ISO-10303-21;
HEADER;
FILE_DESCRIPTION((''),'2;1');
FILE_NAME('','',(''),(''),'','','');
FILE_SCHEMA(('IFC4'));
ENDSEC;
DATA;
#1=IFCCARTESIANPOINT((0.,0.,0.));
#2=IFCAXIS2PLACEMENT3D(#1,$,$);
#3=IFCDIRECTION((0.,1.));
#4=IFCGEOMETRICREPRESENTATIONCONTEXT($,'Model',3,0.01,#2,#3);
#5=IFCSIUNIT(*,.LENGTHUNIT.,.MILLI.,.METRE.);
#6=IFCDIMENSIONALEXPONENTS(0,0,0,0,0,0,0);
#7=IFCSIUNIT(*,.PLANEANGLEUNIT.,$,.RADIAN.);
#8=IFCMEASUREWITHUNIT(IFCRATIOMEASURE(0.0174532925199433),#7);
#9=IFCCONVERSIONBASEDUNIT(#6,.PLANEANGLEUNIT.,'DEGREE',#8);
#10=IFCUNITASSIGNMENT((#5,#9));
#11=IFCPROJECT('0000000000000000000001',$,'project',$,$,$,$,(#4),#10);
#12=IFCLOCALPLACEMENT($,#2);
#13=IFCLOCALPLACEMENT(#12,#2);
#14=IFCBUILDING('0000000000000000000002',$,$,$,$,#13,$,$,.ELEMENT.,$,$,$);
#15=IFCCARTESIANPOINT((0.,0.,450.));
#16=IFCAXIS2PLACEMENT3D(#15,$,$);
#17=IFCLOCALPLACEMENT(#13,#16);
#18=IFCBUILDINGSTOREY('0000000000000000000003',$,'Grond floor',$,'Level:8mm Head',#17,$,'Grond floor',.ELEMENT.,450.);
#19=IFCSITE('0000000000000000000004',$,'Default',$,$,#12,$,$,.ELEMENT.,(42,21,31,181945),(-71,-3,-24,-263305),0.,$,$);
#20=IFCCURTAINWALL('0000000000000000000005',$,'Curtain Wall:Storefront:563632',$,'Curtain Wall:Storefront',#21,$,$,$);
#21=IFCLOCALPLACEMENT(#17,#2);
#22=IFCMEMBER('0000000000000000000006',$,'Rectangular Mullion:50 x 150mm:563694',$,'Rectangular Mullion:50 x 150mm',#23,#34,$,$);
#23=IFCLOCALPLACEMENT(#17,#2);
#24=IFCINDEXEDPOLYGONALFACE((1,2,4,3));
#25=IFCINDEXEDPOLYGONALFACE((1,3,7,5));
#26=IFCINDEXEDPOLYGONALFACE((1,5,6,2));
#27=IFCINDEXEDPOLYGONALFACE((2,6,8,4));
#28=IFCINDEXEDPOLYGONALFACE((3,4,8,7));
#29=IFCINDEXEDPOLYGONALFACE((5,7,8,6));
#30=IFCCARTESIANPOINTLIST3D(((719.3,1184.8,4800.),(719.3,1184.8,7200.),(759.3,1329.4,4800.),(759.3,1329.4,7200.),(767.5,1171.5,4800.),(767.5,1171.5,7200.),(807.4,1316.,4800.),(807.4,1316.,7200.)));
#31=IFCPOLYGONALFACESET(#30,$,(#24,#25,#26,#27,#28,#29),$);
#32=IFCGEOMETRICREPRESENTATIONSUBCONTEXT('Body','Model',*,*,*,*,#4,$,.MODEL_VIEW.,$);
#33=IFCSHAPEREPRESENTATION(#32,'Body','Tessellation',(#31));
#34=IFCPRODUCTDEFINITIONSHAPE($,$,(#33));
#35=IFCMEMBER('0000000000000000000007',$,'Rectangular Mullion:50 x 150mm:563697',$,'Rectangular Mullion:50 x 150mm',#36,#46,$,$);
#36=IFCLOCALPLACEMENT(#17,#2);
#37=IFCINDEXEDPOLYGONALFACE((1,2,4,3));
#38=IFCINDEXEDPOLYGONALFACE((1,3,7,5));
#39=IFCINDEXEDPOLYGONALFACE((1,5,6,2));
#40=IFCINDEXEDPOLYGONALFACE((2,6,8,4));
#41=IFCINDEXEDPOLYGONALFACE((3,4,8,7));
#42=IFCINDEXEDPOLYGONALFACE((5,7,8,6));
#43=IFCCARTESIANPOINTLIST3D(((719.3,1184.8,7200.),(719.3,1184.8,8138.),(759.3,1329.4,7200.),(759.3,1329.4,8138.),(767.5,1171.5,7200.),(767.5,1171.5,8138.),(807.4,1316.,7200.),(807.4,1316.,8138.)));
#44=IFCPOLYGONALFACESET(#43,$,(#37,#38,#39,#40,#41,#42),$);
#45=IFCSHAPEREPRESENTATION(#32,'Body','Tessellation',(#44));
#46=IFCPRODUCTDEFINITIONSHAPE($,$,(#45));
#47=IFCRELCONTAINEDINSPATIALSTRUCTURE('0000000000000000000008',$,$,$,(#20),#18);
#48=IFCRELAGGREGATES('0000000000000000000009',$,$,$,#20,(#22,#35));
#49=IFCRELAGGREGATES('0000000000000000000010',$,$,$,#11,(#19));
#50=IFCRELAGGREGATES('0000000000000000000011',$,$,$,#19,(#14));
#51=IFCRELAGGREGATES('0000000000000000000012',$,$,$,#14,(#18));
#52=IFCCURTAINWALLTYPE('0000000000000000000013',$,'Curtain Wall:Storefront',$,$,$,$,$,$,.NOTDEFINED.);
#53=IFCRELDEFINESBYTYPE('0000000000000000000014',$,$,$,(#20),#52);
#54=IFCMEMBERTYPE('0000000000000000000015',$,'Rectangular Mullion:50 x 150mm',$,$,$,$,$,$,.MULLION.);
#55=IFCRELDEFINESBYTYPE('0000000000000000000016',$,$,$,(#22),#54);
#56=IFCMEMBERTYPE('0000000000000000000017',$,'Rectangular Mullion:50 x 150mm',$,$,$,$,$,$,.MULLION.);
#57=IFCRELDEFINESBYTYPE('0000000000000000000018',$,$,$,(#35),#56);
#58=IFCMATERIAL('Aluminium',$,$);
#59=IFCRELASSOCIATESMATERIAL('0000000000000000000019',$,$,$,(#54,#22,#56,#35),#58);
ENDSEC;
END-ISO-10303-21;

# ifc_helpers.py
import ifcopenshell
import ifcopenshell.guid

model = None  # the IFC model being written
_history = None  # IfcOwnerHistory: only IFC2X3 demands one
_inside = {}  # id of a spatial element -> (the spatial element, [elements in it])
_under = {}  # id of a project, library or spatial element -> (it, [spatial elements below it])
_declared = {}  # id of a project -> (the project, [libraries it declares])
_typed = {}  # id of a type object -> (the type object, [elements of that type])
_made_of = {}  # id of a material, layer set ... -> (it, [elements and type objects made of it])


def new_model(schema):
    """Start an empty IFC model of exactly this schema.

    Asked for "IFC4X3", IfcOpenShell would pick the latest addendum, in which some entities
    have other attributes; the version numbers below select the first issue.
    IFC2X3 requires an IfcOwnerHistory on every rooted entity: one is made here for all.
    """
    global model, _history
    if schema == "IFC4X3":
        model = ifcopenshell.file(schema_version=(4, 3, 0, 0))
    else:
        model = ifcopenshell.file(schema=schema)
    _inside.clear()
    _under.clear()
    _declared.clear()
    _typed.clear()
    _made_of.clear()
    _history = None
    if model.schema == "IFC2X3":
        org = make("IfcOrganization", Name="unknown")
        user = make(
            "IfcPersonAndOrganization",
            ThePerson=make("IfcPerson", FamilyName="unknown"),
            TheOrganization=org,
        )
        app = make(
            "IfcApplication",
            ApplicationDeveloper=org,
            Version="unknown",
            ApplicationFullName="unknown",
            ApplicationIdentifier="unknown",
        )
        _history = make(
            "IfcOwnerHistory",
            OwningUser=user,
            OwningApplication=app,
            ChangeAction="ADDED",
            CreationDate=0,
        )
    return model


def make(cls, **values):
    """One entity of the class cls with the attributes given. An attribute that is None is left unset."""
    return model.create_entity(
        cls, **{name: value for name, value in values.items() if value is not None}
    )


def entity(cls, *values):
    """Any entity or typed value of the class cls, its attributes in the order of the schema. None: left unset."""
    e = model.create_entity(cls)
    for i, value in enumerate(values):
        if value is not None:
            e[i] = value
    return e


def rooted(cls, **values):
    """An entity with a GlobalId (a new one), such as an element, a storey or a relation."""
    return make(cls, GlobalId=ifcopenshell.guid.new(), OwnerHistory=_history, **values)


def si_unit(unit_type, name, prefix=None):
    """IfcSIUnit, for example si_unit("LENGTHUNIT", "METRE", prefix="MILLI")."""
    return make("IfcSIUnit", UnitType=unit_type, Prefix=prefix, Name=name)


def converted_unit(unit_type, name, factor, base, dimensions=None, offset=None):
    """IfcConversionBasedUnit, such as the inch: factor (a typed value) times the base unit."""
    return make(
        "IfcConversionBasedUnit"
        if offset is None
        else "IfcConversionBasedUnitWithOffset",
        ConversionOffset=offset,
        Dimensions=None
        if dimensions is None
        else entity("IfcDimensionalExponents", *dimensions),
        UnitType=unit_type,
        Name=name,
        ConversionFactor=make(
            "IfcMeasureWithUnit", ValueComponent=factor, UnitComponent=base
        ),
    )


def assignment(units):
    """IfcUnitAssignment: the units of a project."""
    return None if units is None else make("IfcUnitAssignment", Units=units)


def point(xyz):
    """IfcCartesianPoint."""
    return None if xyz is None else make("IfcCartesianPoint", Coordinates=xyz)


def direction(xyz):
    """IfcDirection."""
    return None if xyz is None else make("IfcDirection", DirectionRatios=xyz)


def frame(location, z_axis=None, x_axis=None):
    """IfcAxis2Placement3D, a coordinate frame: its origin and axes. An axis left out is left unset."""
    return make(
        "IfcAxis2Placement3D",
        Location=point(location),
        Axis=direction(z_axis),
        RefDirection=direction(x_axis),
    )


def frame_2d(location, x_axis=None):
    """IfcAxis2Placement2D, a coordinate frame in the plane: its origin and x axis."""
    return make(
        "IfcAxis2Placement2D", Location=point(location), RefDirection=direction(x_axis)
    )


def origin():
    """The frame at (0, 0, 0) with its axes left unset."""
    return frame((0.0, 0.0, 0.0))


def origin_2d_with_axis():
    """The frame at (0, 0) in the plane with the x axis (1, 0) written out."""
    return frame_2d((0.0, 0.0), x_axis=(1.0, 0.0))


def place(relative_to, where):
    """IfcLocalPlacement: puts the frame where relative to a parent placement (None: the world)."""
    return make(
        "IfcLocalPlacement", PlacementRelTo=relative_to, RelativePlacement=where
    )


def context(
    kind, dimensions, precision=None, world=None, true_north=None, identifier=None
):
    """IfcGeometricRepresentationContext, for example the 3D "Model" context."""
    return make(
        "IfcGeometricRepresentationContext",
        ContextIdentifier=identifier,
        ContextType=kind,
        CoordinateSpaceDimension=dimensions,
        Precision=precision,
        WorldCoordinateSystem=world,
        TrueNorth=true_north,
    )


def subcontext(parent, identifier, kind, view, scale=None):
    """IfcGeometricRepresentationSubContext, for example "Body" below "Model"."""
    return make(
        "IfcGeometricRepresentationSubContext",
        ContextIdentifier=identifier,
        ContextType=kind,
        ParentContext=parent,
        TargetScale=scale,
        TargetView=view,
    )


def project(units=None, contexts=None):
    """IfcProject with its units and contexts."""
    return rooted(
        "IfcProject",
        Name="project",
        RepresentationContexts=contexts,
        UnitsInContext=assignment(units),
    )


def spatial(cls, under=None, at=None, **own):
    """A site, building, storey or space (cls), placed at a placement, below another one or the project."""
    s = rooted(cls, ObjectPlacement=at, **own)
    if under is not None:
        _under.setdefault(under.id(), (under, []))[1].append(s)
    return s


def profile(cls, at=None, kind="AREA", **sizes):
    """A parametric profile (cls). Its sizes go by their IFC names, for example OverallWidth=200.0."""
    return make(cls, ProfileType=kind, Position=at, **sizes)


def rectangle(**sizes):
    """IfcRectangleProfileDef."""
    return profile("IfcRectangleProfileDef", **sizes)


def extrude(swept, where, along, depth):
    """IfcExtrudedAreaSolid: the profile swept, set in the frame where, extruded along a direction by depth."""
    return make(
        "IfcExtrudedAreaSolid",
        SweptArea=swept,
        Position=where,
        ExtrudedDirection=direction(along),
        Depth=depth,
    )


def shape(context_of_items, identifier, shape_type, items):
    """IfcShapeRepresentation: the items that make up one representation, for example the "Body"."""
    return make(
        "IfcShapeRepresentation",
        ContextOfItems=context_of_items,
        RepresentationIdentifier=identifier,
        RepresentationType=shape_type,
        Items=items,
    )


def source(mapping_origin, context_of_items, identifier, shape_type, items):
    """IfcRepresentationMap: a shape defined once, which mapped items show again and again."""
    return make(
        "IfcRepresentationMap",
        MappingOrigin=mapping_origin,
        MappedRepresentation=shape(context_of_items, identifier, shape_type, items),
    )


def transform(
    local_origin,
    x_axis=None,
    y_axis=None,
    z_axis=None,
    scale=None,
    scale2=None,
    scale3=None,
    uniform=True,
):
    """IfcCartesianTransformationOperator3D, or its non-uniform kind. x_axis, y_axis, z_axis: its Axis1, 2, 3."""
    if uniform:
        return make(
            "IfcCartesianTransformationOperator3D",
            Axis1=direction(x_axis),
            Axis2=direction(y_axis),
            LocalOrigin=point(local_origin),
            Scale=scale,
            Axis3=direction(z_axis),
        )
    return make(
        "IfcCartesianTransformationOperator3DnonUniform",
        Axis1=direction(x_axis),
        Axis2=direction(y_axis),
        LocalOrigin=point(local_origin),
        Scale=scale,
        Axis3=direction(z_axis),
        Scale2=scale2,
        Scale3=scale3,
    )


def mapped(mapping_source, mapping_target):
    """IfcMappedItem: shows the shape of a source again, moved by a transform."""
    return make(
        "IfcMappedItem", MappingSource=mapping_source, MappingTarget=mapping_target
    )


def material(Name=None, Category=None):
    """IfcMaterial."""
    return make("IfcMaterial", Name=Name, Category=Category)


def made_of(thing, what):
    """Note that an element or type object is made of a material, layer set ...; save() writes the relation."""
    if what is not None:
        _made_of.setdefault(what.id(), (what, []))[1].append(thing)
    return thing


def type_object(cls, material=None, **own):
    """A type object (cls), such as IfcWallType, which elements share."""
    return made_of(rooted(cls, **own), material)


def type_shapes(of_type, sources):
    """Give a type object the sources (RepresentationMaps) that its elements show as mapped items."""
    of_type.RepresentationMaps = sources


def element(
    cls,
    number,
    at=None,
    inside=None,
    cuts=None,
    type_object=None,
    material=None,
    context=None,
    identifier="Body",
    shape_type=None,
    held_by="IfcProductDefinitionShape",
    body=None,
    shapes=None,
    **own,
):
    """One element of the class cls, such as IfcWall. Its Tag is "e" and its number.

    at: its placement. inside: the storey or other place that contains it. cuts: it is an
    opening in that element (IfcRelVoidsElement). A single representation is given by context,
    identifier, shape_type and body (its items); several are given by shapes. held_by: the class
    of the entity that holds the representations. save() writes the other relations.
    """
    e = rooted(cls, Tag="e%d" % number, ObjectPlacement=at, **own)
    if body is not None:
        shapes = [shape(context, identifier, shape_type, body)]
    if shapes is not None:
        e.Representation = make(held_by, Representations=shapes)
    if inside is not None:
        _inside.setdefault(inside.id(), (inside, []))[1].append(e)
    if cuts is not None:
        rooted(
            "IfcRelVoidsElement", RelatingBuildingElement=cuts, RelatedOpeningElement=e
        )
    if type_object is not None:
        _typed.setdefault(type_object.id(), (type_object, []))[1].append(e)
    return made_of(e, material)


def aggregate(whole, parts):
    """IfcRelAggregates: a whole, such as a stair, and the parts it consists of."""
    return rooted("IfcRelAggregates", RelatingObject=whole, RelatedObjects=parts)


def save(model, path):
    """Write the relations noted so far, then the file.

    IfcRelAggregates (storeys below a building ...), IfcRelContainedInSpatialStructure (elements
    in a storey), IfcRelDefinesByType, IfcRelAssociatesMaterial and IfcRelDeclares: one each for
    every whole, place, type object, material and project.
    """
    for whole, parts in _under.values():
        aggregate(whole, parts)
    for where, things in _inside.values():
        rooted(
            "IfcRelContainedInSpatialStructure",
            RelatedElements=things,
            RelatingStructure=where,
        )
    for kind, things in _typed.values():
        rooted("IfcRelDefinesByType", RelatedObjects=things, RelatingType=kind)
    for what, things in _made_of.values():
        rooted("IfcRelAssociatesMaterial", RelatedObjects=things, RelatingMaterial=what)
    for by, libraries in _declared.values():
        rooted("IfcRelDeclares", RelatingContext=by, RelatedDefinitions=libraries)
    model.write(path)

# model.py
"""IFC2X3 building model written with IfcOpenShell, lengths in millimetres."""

from ifc_helpers import new_model, entity, si_unit, converted_unit, direction, frame, origin, origin_2d_with_axis, place, context, subcontext, project, spatial, rectangle, extrude, source, transform, mapped, material, type_object, type_shapes, element, aggregate, save


model = new_model("IFC2X3")

# Units and contexts
model_context = context("Model", 3, precision=0.01, world=origin(), true_north=direction((0.0, 1.0)))
body_context = subcontext(model_context, "Body", "Model", "MODEL_VIEW")
ifc_project = project(units=[si_unit("LENGTHUNIT", "METRE", prefix="MILLI"), converted_unit("PLANEANGLEUNIT", "DEGREE", entity("IfcRatioMeasure", 0.0174532925199433), si_unit("PLANEANGLEUNIT", "RADIAN"), dimensions=[0, 0, 0, 0, 0, 0, 0])], contexts=[model_context])

# Site, building, storey
site_placement = place(None, origin())
site = spatial("IfcSite", under=ifc_project, at=site_placement, Name="Default", CompositionType="ELEMENT", RefLatitude=(42, 21, 31, 181945), RefLongitude=(-71, -3, -24, -263305), RefElevation=0.0)
building_placement = place(site_placement, origin())
building = spatial("IfcBuilding", under=site, at=building_placement, CompositionType="ELEMENT")
storey_placement = place(building_placement, frame((0.0, 0.0, 450.0)))
storey = spatial("IfcBuildingStorey", under=building, at=storey_placement, Name="Grond floor", ObjectType="Level:8mm Head", LongName="Grond floor", CompositionType="ELEMENT", Elevation=450.0)

# Curtain wall, members
curtain_wall_type = type_object("IfcCurtainWallType", Name="Curtain Wall:Storefront", PredefinedType="NOTDEFINED")
curtain_wall_placement = place(storey_placement, frame((0.0, 0.0, -450.0)))
curtain_wall = element("IfcCurtainWall", 1, at=curtain_wall_placement, inside=storey, type_object=curtain_wall_type, Name="Curtain Wall:Storefront:563632", ObjectType="Curtain Wall:Storefront")
ifc_material_1 = material(Name="Aluminium")
member_type_1 = type_object("IfcMemberType", Name="Rectangular Mullion:50 x 150mm", PredefinedType="MULLION", material=ifc_material_1)
shared_shape_1 = source(origin(), body_context, "Body", "SweptSolid", [
    extrude(rectangle(XDim=150.0, YDim=50.0, at=origin_2d_with_axis()), frame((0.0, 0.0, -2400.0), z_axis=(0.0, 0.0, 1.0), x_axis=(0.0, -1.0, 0.0)), (0.0, 0.0, 1.0), 2400.0),
])
type_shapes(member_type_1, [shared_shape_1])
member_1_placement = place(storey_placement, frame((763.4, 1250.4, 4800.0), z_axis=(0.0, 0.0, -1.0), x_axis=(-0.963836, 0.266496, 0.0)))
member_1 = element("IfcMember", 2, at=member_1_placement, type_object=member_type_1, material=ifc_material_1, Name="Rectangular Mullion:50 x 150mm:563694", ObjectType="Rectangular Mullion:50 x 150mm", context=body_context, shape_type="MappedRepresentation", body=[
    mapped(shared_shape_1, transform((0.0, 0.0, 0.0), scale=1.0)),
])
member_type_2 = type_object("IfcMemberType", Name="Rectangular Mullion:50 x 150mm", PredefinedType="MULLION", material=ifc_material_1)
shared_shape_2 = source(origin(), body_context, "Body", "SweptSolid", [
    extrude(rectangle(XDim=150.0, YDim=50.0, at=origin_2d_with_axis()), frame((0.0, 0.0, -938.0), z_axis=(0.0, 0.0, 1.0), x_axis=(0.0, -1.0, 0.0)), (0.0, 0.0, 1.0), 938.0),
])
type_shapes(member_type_2, [shared_shape_2])
member_2_placement = place(storey_placement, frame((763.4, 1250.4, 7200.0), z_axis=(0.0, 0.0, -1.0), x_axis=(-0.963836, 0.266496, 0.0)))
member_2 = element("IfcMember", 3, at=member_2_placement, type_object=member_type_2, material=ifc_material_1, Name="Rectangular Mullion:50 x 150mm:563697", ObjectType="Rectangular Mullion:50 x 150mm", context=body_context, shape_type="MappedRepresentation", body=[
    mapped(shared_shape_2, transform((0.0, 0.0, 0.0), scale=1.0)),
])
aggregate(curtain_wall, [member_1, member_2])

save(model, "model.ifc")
